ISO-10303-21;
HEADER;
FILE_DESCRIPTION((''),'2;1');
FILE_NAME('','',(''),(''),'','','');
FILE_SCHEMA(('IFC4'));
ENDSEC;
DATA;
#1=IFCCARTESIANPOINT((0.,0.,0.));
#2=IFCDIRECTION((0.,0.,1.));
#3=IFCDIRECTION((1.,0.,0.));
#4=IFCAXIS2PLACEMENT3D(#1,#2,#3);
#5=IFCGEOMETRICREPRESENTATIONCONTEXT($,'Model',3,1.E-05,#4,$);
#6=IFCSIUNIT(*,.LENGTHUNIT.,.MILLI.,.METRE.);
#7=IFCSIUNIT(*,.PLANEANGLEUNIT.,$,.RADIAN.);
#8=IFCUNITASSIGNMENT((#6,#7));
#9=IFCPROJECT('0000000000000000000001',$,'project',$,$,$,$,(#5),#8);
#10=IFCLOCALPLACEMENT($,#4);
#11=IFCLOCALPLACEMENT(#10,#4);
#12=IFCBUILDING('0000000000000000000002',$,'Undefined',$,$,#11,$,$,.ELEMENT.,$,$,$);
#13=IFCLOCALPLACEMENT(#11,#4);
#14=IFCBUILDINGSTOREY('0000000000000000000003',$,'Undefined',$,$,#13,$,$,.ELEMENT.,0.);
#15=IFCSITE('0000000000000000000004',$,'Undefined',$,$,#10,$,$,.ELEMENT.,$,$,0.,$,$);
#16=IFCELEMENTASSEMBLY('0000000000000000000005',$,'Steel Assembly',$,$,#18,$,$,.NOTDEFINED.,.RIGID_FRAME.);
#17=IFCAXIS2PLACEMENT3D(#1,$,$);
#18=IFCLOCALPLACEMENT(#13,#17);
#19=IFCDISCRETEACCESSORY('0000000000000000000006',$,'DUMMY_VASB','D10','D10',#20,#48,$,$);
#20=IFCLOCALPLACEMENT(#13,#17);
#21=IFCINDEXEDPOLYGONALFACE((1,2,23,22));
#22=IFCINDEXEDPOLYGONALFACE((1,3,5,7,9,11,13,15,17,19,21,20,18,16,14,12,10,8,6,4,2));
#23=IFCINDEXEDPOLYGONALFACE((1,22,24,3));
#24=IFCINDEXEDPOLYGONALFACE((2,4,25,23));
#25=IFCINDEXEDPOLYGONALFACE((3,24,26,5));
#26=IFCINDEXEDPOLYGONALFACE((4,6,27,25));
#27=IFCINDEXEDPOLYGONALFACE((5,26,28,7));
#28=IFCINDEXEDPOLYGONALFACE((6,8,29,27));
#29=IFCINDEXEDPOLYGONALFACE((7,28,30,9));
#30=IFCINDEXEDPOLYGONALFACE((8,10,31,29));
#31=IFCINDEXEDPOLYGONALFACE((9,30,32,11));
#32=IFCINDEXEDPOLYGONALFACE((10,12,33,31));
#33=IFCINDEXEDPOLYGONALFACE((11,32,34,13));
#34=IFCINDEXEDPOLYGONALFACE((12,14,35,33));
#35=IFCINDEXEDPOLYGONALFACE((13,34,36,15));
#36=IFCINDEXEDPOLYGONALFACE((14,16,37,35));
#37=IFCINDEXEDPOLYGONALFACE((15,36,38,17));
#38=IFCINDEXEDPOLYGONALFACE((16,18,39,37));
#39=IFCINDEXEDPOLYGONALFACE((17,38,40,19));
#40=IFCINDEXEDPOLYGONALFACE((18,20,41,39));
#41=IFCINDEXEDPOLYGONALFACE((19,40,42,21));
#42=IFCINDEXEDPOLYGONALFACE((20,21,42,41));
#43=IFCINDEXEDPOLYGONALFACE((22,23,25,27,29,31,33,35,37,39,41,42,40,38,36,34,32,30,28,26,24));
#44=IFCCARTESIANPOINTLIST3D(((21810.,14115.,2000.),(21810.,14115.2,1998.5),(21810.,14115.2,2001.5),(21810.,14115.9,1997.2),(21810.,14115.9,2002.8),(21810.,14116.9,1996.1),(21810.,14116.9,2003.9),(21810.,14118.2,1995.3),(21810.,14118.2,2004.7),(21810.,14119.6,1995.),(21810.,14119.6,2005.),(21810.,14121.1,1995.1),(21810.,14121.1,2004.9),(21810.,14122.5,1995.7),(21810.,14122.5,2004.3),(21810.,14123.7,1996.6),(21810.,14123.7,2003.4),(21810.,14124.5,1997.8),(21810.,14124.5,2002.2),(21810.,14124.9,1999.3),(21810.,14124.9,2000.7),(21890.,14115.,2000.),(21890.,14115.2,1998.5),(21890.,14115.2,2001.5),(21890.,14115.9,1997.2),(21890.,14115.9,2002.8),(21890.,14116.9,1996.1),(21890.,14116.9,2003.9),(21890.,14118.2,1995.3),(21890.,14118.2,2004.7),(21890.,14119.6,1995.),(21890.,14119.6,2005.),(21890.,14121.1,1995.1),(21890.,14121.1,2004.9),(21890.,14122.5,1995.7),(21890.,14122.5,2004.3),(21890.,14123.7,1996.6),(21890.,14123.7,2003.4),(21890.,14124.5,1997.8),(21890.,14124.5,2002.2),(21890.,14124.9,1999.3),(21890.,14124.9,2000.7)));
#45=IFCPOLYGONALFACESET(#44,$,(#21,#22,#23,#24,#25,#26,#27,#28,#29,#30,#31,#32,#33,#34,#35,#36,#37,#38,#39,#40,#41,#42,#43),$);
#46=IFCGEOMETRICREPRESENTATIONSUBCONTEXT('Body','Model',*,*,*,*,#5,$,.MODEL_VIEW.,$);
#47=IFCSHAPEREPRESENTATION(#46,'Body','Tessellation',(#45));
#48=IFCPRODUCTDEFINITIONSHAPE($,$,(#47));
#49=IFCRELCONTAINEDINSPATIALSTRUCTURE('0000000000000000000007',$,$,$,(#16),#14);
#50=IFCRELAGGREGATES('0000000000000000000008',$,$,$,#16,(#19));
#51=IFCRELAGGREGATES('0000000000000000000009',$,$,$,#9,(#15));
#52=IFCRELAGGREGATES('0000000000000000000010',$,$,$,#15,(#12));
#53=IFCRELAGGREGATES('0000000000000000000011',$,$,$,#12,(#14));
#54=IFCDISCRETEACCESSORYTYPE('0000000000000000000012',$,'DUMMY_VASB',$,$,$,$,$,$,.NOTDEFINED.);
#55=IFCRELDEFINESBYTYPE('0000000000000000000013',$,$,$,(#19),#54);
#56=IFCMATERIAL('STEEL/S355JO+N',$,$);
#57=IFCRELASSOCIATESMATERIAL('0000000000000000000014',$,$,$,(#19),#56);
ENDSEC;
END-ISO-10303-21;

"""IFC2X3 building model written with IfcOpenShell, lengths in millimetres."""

from ifc_helpers import new_model, si_unit, frame, origin_with_axes, origin_2d_with_axis, place, context, subcontext, project, spatial, circle, extrude, material, type_object, element, aggregate, save


model = new_model("IFC2X3")

# Units and contexts
model_context = context("Model", 3, precision=1e-05, world=origin_with_axes())
body_context = subcontext(model_context, "Body", "Model", "MODEL_VIEW")
ifc_project = project(units=[si_unit("LENGTHUNIT", "METRE", prefix="MILLI"), si_unit("PLANEANGLEUNIT", "RADIAN")], contexts=[model_context])

# Site, building, storey
site_placement = place(None, origin_with_axes())
site = spatial("IfcSite", under=ifc_project, at=site_placement, Name="Undefined", CompositionType="ELEMENT", RefElevation=0.0)
building_placement = place(site_placement, origin_with_axes())
building = spatial("IfcBuilding", under=site, at=building_placement, Name="Undefined", CompositionType="ELEMENT")
storey_placement = place(building_placement, origin_with_axes())
storey = spatial("IfcBuildingStorey", under=building, at=storey_placement, Name="Undefined", CompositionType="ELEMENT", Elevation=0.0)

# Element assembly
assembly_1_placement = place(storey_placement, origin_with_axes())
assembly_1 = element("IfcElementAssembly", 1, at=assembly_1_placement, inside=storey, Name="Steel Assembly", AssemblyPlace="NOTDEFINED", PredefinedType="RIGID_FRAME")
ifc_material_1 = material(Name="STEEL/S355JO+N")

# Discrete accessory
discrete_accessory_type = type_object("IfcDiscreteAccessoryType", Name="DUMMY_VASB")
discrete_accessory_placement = place(assembly_1_placement, frame((21810.0, 14120.0, 2000.0), z_axis=(0.0, 0.0, 1.0), x_axis=(1.0, 0.0, 0.0)))
discrete_accessory = element("IfcDiscreteAccessory", 2, at=discrete_accessory_placement, type_object=discrete_accessory_type, material=ifc_material_1, Name="DUMMY_VASB", Description="D10", ObjectType="D10", context=body_context, shape_type="SweptSolid", body=[
    extrude(circle(Radius=5.0, at=origin_2d_with_axis()), frame((80.0, 0.0, 0.0), z_axis=(-1.0, 0.0, 0.0), x_axis=(0.0, -1.0, 0.0)), (0.0, 0.0, 1.0), 80.0),
])
aggregate(assembly_1, [discrete_accessory])

save(model, "model.ifc")
